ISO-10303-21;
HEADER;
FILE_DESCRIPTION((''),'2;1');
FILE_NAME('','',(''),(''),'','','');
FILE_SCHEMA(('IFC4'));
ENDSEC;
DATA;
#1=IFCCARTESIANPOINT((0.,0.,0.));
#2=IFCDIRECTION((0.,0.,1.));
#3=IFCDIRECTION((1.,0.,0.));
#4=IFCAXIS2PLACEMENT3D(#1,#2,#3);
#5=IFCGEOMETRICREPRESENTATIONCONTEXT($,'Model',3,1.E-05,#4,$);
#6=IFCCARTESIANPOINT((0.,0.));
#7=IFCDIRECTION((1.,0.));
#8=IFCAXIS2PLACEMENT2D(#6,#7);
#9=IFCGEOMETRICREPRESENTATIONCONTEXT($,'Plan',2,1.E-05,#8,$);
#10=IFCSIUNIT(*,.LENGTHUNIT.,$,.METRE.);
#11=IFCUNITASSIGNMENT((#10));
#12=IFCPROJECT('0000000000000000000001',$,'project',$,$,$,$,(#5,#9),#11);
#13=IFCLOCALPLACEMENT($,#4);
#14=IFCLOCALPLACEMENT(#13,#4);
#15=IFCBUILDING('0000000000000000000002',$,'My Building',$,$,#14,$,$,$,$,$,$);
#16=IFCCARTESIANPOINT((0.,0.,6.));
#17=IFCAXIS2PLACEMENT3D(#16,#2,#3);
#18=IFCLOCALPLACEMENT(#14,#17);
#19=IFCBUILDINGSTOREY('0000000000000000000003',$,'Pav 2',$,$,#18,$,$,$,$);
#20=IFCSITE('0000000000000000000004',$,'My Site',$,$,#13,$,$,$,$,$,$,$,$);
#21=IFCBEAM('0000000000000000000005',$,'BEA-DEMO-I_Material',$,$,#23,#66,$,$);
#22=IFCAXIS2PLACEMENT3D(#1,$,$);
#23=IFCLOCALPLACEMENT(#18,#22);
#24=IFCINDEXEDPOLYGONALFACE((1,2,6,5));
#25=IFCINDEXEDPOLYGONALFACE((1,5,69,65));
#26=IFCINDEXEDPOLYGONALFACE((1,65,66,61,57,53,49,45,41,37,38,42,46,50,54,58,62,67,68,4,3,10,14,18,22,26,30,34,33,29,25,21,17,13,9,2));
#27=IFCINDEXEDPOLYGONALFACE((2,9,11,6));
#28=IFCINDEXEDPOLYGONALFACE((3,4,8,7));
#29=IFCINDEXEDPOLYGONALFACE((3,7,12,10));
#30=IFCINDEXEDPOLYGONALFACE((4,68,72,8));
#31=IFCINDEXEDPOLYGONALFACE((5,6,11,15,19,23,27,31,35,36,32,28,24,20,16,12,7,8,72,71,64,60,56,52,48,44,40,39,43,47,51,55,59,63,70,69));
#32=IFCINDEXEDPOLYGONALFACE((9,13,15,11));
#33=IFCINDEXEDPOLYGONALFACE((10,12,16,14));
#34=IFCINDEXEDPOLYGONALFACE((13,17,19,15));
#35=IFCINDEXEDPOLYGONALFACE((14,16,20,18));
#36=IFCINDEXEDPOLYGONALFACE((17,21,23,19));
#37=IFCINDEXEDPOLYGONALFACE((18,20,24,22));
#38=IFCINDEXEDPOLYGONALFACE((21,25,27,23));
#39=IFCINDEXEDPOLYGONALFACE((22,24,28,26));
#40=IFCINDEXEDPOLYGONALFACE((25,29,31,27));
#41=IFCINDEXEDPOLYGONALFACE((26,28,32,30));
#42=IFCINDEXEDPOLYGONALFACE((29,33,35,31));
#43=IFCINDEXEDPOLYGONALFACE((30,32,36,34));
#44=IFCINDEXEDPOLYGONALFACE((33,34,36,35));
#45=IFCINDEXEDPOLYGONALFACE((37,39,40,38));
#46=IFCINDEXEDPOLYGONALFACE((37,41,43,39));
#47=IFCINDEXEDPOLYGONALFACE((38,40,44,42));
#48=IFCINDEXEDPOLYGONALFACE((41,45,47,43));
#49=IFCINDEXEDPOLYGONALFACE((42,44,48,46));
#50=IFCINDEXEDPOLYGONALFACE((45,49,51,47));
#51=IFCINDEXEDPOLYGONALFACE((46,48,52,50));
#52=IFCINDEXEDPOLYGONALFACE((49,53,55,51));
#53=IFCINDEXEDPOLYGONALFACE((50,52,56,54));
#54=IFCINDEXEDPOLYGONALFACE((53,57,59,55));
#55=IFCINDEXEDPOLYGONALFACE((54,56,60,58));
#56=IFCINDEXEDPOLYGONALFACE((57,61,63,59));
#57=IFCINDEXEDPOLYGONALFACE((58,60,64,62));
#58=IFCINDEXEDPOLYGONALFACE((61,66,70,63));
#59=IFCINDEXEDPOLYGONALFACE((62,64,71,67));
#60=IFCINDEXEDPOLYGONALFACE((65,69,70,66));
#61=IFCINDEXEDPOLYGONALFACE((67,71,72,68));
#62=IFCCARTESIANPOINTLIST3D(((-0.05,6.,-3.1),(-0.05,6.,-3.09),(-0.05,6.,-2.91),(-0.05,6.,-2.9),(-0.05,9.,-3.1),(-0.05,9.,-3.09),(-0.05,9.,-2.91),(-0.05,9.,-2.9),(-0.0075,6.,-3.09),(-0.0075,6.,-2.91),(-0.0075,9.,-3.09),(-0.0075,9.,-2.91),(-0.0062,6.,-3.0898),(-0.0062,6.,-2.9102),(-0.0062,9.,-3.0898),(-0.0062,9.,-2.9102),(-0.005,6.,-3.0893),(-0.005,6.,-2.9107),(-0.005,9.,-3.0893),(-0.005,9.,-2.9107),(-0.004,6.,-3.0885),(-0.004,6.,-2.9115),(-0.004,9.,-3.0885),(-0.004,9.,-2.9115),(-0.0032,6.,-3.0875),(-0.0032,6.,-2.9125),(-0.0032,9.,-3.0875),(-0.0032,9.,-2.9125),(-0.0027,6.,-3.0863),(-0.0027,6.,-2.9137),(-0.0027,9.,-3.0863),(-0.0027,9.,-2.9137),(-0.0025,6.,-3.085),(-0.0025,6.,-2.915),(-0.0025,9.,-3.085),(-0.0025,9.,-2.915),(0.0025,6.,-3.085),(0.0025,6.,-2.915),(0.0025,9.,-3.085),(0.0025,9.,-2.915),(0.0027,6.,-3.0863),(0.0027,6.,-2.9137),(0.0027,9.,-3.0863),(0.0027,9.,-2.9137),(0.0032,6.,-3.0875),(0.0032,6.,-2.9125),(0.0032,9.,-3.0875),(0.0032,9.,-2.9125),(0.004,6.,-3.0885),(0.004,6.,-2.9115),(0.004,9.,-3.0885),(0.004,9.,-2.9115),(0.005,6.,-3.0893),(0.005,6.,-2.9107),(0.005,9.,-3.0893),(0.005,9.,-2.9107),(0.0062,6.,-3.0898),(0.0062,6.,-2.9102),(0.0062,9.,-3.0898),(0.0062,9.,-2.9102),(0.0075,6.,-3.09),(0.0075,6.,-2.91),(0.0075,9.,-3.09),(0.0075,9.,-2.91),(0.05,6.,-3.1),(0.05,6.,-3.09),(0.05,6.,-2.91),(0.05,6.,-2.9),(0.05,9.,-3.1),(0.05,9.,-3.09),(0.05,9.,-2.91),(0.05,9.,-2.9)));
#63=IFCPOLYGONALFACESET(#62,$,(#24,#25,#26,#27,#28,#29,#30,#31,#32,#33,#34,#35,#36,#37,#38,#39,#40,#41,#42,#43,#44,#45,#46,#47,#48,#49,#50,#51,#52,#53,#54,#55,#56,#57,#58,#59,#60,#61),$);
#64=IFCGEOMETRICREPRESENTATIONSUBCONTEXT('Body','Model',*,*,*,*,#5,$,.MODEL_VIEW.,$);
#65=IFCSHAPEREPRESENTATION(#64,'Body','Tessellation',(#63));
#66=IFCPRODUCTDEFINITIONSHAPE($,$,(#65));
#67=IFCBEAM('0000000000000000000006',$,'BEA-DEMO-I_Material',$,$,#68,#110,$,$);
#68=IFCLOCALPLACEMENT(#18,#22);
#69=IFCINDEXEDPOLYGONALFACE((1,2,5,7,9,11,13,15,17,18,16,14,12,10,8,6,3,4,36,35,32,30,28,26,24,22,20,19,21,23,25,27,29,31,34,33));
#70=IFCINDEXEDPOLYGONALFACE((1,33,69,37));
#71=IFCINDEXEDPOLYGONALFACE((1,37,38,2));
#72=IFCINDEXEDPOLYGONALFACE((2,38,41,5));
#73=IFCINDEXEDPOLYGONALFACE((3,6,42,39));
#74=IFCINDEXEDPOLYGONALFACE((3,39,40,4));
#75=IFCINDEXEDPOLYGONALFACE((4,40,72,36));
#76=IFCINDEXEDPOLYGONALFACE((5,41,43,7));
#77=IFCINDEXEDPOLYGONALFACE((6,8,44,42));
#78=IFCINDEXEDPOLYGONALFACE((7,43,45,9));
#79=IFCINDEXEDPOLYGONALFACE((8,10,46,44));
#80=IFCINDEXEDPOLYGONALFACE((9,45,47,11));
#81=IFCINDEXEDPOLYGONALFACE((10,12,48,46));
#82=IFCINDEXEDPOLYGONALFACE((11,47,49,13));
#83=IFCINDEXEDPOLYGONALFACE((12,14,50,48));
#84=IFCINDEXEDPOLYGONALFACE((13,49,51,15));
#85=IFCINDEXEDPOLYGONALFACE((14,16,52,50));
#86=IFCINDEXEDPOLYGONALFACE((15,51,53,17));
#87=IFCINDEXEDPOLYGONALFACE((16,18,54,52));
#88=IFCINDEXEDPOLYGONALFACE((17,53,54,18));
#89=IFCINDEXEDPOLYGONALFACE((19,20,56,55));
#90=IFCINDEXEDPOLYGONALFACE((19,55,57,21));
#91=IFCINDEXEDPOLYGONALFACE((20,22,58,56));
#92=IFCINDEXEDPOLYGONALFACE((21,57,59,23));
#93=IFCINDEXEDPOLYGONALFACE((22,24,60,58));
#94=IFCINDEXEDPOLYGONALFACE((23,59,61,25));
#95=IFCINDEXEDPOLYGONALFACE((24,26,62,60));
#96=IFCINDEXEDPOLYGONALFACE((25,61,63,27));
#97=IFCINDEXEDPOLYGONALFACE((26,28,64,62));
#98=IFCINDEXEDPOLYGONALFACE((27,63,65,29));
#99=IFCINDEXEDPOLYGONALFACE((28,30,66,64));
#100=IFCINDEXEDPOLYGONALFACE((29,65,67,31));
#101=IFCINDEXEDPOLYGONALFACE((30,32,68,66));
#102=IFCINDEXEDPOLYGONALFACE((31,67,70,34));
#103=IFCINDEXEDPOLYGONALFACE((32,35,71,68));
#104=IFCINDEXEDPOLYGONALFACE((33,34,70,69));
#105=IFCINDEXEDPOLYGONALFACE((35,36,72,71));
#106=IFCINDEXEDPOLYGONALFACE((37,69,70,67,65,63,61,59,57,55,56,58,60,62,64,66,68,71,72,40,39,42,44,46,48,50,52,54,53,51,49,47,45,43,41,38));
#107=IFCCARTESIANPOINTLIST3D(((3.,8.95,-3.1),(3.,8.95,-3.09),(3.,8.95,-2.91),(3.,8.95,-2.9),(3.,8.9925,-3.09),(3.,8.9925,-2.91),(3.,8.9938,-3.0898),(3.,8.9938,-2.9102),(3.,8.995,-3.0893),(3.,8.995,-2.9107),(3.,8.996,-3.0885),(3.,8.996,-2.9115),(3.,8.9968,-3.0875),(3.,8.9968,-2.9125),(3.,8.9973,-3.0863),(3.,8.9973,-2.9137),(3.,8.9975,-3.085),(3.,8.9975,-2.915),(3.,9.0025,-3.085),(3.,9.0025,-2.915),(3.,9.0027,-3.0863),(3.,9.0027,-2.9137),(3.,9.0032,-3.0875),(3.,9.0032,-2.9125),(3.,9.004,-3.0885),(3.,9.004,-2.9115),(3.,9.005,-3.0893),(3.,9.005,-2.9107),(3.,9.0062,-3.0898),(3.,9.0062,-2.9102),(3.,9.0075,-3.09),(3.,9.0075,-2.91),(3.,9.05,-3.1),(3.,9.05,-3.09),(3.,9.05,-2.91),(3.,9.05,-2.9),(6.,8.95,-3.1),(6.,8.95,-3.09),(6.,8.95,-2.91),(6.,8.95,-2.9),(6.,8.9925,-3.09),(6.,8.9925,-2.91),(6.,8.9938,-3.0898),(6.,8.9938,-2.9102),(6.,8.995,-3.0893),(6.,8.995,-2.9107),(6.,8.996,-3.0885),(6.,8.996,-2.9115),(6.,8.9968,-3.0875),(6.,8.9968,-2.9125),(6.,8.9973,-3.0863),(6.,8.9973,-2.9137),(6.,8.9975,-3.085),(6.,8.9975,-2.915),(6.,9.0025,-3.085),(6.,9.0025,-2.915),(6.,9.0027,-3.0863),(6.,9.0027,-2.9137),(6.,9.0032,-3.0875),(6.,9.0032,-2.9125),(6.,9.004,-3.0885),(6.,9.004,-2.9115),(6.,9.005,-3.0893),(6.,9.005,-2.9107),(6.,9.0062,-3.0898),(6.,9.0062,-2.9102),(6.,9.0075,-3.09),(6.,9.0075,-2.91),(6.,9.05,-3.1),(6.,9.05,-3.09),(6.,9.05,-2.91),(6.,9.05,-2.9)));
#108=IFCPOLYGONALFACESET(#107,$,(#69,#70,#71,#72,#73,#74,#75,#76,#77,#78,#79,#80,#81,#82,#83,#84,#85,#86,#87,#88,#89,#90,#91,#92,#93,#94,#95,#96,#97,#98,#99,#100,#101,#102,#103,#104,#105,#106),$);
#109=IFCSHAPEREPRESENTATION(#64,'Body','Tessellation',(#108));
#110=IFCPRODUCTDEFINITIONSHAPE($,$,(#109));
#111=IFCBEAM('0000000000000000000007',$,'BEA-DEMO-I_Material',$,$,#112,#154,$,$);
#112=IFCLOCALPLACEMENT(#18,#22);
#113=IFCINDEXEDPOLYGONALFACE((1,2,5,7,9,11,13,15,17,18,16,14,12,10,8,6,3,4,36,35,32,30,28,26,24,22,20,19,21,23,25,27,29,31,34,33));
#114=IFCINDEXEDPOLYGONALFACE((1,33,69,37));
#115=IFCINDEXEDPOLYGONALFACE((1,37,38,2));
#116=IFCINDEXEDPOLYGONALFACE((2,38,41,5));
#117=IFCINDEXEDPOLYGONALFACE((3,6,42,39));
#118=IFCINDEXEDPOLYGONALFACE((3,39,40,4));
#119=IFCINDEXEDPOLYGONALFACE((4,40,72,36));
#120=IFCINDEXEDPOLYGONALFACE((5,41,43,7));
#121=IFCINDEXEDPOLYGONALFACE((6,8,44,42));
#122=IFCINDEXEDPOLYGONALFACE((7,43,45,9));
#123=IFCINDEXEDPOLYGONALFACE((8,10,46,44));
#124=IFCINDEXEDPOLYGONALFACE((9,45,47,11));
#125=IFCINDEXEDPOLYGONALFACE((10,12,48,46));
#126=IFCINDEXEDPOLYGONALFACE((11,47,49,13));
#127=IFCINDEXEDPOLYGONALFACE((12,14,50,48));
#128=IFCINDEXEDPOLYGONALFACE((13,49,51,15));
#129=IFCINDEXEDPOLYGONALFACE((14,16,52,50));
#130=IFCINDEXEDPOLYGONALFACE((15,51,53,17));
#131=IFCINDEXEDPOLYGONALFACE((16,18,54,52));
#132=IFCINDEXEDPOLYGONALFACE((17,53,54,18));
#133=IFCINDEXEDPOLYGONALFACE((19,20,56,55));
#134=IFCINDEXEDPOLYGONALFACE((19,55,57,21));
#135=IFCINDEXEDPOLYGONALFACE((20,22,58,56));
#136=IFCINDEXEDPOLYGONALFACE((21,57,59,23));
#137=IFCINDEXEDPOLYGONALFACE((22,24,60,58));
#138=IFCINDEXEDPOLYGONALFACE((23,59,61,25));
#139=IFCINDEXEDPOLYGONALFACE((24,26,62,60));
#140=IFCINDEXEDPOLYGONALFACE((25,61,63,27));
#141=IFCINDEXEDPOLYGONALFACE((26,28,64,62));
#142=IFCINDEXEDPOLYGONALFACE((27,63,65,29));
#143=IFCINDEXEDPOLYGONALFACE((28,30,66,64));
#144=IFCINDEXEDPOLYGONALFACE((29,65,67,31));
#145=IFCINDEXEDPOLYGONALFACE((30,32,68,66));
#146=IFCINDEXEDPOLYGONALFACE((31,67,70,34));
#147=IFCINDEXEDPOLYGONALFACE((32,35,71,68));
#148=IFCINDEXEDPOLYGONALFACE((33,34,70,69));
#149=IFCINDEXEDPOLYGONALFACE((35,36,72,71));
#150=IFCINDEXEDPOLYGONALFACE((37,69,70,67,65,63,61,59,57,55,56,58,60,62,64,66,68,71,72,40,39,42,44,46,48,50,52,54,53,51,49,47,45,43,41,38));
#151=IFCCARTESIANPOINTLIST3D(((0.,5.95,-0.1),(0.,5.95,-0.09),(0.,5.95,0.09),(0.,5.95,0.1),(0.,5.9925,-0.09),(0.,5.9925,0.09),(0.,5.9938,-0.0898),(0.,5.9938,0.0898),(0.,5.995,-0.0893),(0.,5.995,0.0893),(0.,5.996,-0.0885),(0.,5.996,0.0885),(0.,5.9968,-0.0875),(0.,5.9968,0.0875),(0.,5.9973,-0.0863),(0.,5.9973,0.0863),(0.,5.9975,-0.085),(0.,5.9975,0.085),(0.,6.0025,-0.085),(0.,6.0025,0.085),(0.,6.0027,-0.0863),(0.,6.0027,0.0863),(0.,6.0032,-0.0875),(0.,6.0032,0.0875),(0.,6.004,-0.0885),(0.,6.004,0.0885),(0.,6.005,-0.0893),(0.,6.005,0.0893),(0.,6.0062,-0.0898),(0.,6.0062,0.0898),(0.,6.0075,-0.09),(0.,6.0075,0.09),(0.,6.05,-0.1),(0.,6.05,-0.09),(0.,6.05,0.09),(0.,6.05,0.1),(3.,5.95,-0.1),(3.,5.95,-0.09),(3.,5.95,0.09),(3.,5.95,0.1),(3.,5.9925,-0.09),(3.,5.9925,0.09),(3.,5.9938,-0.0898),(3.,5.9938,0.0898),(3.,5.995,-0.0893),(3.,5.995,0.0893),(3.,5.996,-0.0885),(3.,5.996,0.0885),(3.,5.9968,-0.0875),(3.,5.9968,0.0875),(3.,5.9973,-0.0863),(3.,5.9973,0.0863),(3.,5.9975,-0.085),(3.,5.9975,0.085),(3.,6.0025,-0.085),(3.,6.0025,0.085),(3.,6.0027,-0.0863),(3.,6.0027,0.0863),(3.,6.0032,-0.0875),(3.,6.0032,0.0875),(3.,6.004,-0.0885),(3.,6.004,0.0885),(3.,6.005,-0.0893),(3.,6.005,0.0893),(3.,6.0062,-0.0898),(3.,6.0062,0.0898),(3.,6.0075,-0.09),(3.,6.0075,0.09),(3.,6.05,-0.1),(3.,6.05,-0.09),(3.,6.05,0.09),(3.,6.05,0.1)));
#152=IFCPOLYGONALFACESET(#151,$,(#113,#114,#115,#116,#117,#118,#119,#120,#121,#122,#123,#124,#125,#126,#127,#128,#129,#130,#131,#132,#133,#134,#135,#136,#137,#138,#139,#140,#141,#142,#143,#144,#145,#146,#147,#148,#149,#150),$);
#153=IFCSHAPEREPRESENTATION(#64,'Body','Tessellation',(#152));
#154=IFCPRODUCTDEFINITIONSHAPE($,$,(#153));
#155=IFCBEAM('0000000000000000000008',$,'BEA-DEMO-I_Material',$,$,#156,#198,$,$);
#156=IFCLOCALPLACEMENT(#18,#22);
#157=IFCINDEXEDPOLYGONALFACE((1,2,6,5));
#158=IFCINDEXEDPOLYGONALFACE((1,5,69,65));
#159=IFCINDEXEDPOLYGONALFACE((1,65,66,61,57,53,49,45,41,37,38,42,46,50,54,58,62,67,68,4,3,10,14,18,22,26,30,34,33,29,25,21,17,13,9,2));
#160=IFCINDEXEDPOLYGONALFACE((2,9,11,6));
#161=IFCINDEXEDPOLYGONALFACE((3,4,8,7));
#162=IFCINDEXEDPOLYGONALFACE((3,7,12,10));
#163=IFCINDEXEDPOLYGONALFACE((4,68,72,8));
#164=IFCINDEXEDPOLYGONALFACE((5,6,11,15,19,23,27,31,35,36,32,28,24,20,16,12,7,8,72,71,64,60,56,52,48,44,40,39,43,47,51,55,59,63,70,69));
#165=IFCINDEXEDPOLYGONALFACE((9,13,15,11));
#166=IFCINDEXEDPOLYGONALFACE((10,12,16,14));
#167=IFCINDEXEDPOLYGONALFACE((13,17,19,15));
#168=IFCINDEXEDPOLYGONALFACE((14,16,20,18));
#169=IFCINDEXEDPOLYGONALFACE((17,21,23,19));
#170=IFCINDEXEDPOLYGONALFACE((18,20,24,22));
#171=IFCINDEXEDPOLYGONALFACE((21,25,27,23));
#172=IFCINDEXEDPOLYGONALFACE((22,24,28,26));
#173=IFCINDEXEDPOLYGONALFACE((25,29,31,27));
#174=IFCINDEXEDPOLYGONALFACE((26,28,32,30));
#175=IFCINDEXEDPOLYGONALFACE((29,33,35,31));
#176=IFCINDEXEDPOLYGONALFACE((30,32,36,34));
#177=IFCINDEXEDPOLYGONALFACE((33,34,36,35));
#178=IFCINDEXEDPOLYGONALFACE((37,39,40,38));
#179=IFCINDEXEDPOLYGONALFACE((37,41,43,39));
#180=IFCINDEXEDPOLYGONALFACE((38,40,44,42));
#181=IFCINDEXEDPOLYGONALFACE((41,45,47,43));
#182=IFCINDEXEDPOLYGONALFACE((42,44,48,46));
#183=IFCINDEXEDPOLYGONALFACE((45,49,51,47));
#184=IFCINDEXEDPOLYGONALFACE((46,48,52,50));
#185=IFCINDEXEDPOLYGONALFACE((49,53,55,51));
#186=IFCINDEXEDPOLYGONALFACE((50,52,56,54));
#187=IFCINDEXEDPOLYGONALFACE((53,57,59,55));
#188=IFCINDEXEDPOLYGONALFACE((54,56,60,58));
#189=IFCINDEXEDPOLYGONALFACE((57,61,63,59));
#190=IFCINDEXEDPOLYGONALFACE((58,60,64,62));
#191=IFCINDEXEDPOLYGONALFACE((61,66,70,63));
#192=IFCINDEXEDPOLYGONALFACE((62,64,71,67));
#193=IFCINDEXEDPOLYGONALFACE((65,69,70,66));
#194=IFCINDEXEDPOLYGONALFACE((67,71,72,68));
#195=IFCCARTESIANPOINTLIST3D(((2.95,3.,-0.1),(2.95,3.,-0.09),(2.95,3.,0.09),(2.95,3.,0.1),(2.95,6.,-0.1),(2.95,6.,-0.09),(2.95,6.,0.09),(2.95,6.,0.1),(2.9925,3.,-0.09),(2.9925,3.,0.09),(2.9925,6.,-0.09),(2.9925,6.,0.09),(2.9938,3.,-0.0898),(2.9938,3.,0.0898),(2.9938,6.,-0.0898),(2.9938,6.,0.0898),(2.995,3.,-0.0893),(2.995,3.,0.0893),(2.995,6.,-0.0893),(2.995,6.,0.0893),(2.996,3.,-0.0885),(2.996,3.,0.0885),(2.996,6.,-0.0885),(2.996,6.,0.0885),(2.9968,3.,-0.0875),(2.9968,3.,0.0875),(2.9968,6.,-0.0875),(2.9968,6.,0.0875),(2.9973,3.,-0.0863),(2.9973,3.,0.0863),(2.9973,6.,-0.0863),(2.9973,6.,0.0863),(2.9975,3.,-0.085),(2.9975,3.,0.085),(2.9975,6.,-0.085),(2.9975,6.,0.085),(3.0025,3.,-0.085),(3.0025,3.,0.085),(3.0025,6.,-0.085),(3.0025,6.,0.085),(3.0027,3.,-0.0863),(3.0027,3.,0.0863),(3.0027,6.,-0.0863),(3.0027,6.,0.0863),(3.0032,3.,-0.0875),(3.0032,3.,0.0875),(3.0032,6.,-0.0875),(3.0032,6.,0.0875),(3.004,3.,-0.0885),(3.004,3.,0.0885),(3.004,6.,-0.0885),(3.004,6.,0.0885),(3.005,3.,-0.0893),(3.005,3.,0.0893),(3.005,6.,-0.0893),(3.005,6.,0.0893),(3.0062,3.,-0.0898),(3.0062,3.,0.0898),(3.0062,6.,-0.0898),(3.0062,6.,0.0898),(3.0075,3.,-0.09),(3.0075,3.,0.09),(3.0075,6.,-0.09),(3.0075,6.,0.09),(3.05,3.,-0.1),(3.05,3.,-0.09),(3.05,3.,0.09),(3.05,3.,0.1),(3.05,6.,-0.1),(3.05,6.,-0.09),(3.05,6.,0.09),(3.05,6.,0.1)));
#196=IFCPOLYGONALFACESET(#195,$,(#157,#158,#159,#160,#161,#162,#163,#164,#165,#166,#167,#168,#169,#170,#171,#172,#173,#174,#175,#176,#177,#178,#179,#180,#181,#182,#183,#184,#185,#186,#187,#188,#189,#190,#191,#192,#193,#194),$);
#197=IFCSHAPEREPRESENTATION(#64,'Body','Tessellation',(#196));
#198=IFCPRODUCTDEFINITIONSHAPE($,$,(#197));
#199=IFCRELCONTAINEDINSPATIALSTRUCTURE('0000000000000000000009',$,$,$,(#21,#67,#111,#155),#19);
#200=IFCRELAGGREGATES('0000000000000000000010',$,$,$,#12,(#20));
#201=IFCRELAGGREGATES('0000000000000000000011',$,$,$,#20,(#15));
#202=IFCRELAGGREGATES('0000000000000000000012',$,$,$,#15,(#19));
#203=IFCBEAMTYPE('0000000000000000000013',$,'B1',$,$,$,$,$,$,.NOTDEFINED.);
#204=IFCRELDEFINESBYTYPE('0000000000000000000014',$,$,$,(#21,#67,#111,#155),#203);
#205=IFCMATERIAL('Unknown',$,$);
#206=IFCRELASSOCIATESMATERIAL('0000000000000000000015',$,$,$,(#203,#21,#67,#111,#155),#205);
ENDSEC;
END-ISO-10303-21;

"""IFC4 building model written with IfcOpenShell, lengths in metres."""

from ifc_helpers import new_model, si_unit, frame, origin, origin_with_axes, origin_2d_with_axis, place, context, subcontext, project, spatial, i_section, extrude, material, material_profile, profile_set, profile_usage, type_object, element, save


model = new_model("IFC4")

# Units and contexts
model_context = context("Model", 3, precision=1e-05, world=origin_with_axes())
plan_context = context("Plan", 2, precision=1e-05, world=origin_2d_with_axis())
body_context = subcontext(model_context, "Body", "Model", "MODEL_VIEW")
ifc_project = project(units=[si_unit("LENGTHUNIT", "METRE")], contexts=[model_context, plan_context])

# Site, building, storey
site_placement = place(None, origin_with_axes())
site = spatial("IfcSite", under=ifc_project, at=site_placement, Name="My Site")
building_placement = place(site_placement, origin_with_axes())
building = spatial("IfcBuilding", under=site, at=building_placement, Name="My Building")
storey_placement = place(building_placement, frame((0.0, 0.0, 6.0), z_axis=(0.0, 0.0, 1.0), x_axis=(1.0, 0.0, 0.0)))
storey = spatial("IfcBuildingStorey", under=building, at=storey_placement, Name="Pav 2")

# Beams
ifc_material = material(Name="Unknown")
ifc_material_profile = material_profile(ifc_material, i_section(OverallWidth=0.1, OverallDepth=0.2, WebThickness=0.005, FlangeThickness=0.01, FilletRadius=0.005))
ifc_profile_set = profile_set([ifc_material_profile])
beam_type = type_object("IfcBeamType", Name="B1", PredefinedType="NOTDEFINED", material=ifc_profile_set)
ifc_profile_usage_1 = profile_usage(ifc_profile_set, cardinal=5)
beam_1_placement = place(storey_placement, frame((0.0, 6.0, -3.0), z_axis=(0.0, 1.0, 0.0), x_axis=(-1.0, 0.0, 0.0)))
element("IfcBeam", 1, at=beam_1_placement, inside=storey, type_object=beam_type, material=ifc_profile_usage_1, Name="BEA-DEMO-I_Material", context=body_context, shape_type="SweptSolid", body=[
    extrude(i_section(OverallWidth=0.1, OverallDepth=0.2, WebThickness=0.005, FlangeThickness=0.01, FilletRadius=0.005), origin(), (0.0, 0.0, 1.0), 3.0),
])
ifc_profile_usage_2 = profile_usage(ifc_profile_set, cardinal=5)
beam_2_placement = place(storey_placement, frame((3.0, 9.0, -3.0), z_axis=(1.0, 0.0, 0.0), x_axis=(0.0, 1.0, 0.0)))
element("IfcBeam", 2, at=beam_2_placement, inside=storey, type_object=beam_type, material=ifc_profile_usage_2, Name="BEA-DEMO-I_Material", context=body_context, shape_type="SweptSolid", body=[
    extrude(i_section(OverallWidth=0.1, OverallDepth=0.2, WebThickness=0.005, FlangeThickness=0.01, FilletRadius=0.005), origin(), (0.0, 0.0, 1.0), 3.0),
])
ifc_profile_usage_3 = profile_usage(ifc_profile_set, cardinal=5)
beam_3_placement = place(storey_placement, frame((0.0, 6.0, 0.0), z_axis=(1.0, 0.0, 0.0), x_axis=(0.0, 1.0, 0.0)))
element("IfcBeam", 3, at=beam_3_placement, inside=storey, type_object=beam_type, material=ifc_profile_usage_3, Name="BEA-DEMO-I_Material", context=body_context, shape_type="SweptSolid", body=[
    extrude(i_section(OverallWidth=0.1, OverallDepth=0.2, WebThickness=0.005, FlangeThickness=0.01, FilletRadius=0.005), origin(), (0.0, 0.0, 1.0), 3.0),
])
ifc_profile_usage_4 = profile_usage(ifc_profile_set, cardinal=5)
beam_4_placement = place(storey_placement, frame((3.0, 6.0, 0.0), z_axis=(0.0, -1.0, 0.0), x_axis=(1.0, 0.0, 0.0)))
element("IfcBeam", 4, at=beam_4_placement, inside=storey, type_object=beam_type, material=ifc_profile_usage_4, Name="BEA-DEMO-I_Material", context=body_context, shape_type="SweptSolid", body=[
    extrude(i_section(OverallWidth=0.1, OverallDepth=0.2, WebThickness=0.005, FlangeThickness=0.01, FilletRadius=0.005), origin(), (0.0, 0.0, 1.0), 3.0),
])

save(model, "model.ifc")
